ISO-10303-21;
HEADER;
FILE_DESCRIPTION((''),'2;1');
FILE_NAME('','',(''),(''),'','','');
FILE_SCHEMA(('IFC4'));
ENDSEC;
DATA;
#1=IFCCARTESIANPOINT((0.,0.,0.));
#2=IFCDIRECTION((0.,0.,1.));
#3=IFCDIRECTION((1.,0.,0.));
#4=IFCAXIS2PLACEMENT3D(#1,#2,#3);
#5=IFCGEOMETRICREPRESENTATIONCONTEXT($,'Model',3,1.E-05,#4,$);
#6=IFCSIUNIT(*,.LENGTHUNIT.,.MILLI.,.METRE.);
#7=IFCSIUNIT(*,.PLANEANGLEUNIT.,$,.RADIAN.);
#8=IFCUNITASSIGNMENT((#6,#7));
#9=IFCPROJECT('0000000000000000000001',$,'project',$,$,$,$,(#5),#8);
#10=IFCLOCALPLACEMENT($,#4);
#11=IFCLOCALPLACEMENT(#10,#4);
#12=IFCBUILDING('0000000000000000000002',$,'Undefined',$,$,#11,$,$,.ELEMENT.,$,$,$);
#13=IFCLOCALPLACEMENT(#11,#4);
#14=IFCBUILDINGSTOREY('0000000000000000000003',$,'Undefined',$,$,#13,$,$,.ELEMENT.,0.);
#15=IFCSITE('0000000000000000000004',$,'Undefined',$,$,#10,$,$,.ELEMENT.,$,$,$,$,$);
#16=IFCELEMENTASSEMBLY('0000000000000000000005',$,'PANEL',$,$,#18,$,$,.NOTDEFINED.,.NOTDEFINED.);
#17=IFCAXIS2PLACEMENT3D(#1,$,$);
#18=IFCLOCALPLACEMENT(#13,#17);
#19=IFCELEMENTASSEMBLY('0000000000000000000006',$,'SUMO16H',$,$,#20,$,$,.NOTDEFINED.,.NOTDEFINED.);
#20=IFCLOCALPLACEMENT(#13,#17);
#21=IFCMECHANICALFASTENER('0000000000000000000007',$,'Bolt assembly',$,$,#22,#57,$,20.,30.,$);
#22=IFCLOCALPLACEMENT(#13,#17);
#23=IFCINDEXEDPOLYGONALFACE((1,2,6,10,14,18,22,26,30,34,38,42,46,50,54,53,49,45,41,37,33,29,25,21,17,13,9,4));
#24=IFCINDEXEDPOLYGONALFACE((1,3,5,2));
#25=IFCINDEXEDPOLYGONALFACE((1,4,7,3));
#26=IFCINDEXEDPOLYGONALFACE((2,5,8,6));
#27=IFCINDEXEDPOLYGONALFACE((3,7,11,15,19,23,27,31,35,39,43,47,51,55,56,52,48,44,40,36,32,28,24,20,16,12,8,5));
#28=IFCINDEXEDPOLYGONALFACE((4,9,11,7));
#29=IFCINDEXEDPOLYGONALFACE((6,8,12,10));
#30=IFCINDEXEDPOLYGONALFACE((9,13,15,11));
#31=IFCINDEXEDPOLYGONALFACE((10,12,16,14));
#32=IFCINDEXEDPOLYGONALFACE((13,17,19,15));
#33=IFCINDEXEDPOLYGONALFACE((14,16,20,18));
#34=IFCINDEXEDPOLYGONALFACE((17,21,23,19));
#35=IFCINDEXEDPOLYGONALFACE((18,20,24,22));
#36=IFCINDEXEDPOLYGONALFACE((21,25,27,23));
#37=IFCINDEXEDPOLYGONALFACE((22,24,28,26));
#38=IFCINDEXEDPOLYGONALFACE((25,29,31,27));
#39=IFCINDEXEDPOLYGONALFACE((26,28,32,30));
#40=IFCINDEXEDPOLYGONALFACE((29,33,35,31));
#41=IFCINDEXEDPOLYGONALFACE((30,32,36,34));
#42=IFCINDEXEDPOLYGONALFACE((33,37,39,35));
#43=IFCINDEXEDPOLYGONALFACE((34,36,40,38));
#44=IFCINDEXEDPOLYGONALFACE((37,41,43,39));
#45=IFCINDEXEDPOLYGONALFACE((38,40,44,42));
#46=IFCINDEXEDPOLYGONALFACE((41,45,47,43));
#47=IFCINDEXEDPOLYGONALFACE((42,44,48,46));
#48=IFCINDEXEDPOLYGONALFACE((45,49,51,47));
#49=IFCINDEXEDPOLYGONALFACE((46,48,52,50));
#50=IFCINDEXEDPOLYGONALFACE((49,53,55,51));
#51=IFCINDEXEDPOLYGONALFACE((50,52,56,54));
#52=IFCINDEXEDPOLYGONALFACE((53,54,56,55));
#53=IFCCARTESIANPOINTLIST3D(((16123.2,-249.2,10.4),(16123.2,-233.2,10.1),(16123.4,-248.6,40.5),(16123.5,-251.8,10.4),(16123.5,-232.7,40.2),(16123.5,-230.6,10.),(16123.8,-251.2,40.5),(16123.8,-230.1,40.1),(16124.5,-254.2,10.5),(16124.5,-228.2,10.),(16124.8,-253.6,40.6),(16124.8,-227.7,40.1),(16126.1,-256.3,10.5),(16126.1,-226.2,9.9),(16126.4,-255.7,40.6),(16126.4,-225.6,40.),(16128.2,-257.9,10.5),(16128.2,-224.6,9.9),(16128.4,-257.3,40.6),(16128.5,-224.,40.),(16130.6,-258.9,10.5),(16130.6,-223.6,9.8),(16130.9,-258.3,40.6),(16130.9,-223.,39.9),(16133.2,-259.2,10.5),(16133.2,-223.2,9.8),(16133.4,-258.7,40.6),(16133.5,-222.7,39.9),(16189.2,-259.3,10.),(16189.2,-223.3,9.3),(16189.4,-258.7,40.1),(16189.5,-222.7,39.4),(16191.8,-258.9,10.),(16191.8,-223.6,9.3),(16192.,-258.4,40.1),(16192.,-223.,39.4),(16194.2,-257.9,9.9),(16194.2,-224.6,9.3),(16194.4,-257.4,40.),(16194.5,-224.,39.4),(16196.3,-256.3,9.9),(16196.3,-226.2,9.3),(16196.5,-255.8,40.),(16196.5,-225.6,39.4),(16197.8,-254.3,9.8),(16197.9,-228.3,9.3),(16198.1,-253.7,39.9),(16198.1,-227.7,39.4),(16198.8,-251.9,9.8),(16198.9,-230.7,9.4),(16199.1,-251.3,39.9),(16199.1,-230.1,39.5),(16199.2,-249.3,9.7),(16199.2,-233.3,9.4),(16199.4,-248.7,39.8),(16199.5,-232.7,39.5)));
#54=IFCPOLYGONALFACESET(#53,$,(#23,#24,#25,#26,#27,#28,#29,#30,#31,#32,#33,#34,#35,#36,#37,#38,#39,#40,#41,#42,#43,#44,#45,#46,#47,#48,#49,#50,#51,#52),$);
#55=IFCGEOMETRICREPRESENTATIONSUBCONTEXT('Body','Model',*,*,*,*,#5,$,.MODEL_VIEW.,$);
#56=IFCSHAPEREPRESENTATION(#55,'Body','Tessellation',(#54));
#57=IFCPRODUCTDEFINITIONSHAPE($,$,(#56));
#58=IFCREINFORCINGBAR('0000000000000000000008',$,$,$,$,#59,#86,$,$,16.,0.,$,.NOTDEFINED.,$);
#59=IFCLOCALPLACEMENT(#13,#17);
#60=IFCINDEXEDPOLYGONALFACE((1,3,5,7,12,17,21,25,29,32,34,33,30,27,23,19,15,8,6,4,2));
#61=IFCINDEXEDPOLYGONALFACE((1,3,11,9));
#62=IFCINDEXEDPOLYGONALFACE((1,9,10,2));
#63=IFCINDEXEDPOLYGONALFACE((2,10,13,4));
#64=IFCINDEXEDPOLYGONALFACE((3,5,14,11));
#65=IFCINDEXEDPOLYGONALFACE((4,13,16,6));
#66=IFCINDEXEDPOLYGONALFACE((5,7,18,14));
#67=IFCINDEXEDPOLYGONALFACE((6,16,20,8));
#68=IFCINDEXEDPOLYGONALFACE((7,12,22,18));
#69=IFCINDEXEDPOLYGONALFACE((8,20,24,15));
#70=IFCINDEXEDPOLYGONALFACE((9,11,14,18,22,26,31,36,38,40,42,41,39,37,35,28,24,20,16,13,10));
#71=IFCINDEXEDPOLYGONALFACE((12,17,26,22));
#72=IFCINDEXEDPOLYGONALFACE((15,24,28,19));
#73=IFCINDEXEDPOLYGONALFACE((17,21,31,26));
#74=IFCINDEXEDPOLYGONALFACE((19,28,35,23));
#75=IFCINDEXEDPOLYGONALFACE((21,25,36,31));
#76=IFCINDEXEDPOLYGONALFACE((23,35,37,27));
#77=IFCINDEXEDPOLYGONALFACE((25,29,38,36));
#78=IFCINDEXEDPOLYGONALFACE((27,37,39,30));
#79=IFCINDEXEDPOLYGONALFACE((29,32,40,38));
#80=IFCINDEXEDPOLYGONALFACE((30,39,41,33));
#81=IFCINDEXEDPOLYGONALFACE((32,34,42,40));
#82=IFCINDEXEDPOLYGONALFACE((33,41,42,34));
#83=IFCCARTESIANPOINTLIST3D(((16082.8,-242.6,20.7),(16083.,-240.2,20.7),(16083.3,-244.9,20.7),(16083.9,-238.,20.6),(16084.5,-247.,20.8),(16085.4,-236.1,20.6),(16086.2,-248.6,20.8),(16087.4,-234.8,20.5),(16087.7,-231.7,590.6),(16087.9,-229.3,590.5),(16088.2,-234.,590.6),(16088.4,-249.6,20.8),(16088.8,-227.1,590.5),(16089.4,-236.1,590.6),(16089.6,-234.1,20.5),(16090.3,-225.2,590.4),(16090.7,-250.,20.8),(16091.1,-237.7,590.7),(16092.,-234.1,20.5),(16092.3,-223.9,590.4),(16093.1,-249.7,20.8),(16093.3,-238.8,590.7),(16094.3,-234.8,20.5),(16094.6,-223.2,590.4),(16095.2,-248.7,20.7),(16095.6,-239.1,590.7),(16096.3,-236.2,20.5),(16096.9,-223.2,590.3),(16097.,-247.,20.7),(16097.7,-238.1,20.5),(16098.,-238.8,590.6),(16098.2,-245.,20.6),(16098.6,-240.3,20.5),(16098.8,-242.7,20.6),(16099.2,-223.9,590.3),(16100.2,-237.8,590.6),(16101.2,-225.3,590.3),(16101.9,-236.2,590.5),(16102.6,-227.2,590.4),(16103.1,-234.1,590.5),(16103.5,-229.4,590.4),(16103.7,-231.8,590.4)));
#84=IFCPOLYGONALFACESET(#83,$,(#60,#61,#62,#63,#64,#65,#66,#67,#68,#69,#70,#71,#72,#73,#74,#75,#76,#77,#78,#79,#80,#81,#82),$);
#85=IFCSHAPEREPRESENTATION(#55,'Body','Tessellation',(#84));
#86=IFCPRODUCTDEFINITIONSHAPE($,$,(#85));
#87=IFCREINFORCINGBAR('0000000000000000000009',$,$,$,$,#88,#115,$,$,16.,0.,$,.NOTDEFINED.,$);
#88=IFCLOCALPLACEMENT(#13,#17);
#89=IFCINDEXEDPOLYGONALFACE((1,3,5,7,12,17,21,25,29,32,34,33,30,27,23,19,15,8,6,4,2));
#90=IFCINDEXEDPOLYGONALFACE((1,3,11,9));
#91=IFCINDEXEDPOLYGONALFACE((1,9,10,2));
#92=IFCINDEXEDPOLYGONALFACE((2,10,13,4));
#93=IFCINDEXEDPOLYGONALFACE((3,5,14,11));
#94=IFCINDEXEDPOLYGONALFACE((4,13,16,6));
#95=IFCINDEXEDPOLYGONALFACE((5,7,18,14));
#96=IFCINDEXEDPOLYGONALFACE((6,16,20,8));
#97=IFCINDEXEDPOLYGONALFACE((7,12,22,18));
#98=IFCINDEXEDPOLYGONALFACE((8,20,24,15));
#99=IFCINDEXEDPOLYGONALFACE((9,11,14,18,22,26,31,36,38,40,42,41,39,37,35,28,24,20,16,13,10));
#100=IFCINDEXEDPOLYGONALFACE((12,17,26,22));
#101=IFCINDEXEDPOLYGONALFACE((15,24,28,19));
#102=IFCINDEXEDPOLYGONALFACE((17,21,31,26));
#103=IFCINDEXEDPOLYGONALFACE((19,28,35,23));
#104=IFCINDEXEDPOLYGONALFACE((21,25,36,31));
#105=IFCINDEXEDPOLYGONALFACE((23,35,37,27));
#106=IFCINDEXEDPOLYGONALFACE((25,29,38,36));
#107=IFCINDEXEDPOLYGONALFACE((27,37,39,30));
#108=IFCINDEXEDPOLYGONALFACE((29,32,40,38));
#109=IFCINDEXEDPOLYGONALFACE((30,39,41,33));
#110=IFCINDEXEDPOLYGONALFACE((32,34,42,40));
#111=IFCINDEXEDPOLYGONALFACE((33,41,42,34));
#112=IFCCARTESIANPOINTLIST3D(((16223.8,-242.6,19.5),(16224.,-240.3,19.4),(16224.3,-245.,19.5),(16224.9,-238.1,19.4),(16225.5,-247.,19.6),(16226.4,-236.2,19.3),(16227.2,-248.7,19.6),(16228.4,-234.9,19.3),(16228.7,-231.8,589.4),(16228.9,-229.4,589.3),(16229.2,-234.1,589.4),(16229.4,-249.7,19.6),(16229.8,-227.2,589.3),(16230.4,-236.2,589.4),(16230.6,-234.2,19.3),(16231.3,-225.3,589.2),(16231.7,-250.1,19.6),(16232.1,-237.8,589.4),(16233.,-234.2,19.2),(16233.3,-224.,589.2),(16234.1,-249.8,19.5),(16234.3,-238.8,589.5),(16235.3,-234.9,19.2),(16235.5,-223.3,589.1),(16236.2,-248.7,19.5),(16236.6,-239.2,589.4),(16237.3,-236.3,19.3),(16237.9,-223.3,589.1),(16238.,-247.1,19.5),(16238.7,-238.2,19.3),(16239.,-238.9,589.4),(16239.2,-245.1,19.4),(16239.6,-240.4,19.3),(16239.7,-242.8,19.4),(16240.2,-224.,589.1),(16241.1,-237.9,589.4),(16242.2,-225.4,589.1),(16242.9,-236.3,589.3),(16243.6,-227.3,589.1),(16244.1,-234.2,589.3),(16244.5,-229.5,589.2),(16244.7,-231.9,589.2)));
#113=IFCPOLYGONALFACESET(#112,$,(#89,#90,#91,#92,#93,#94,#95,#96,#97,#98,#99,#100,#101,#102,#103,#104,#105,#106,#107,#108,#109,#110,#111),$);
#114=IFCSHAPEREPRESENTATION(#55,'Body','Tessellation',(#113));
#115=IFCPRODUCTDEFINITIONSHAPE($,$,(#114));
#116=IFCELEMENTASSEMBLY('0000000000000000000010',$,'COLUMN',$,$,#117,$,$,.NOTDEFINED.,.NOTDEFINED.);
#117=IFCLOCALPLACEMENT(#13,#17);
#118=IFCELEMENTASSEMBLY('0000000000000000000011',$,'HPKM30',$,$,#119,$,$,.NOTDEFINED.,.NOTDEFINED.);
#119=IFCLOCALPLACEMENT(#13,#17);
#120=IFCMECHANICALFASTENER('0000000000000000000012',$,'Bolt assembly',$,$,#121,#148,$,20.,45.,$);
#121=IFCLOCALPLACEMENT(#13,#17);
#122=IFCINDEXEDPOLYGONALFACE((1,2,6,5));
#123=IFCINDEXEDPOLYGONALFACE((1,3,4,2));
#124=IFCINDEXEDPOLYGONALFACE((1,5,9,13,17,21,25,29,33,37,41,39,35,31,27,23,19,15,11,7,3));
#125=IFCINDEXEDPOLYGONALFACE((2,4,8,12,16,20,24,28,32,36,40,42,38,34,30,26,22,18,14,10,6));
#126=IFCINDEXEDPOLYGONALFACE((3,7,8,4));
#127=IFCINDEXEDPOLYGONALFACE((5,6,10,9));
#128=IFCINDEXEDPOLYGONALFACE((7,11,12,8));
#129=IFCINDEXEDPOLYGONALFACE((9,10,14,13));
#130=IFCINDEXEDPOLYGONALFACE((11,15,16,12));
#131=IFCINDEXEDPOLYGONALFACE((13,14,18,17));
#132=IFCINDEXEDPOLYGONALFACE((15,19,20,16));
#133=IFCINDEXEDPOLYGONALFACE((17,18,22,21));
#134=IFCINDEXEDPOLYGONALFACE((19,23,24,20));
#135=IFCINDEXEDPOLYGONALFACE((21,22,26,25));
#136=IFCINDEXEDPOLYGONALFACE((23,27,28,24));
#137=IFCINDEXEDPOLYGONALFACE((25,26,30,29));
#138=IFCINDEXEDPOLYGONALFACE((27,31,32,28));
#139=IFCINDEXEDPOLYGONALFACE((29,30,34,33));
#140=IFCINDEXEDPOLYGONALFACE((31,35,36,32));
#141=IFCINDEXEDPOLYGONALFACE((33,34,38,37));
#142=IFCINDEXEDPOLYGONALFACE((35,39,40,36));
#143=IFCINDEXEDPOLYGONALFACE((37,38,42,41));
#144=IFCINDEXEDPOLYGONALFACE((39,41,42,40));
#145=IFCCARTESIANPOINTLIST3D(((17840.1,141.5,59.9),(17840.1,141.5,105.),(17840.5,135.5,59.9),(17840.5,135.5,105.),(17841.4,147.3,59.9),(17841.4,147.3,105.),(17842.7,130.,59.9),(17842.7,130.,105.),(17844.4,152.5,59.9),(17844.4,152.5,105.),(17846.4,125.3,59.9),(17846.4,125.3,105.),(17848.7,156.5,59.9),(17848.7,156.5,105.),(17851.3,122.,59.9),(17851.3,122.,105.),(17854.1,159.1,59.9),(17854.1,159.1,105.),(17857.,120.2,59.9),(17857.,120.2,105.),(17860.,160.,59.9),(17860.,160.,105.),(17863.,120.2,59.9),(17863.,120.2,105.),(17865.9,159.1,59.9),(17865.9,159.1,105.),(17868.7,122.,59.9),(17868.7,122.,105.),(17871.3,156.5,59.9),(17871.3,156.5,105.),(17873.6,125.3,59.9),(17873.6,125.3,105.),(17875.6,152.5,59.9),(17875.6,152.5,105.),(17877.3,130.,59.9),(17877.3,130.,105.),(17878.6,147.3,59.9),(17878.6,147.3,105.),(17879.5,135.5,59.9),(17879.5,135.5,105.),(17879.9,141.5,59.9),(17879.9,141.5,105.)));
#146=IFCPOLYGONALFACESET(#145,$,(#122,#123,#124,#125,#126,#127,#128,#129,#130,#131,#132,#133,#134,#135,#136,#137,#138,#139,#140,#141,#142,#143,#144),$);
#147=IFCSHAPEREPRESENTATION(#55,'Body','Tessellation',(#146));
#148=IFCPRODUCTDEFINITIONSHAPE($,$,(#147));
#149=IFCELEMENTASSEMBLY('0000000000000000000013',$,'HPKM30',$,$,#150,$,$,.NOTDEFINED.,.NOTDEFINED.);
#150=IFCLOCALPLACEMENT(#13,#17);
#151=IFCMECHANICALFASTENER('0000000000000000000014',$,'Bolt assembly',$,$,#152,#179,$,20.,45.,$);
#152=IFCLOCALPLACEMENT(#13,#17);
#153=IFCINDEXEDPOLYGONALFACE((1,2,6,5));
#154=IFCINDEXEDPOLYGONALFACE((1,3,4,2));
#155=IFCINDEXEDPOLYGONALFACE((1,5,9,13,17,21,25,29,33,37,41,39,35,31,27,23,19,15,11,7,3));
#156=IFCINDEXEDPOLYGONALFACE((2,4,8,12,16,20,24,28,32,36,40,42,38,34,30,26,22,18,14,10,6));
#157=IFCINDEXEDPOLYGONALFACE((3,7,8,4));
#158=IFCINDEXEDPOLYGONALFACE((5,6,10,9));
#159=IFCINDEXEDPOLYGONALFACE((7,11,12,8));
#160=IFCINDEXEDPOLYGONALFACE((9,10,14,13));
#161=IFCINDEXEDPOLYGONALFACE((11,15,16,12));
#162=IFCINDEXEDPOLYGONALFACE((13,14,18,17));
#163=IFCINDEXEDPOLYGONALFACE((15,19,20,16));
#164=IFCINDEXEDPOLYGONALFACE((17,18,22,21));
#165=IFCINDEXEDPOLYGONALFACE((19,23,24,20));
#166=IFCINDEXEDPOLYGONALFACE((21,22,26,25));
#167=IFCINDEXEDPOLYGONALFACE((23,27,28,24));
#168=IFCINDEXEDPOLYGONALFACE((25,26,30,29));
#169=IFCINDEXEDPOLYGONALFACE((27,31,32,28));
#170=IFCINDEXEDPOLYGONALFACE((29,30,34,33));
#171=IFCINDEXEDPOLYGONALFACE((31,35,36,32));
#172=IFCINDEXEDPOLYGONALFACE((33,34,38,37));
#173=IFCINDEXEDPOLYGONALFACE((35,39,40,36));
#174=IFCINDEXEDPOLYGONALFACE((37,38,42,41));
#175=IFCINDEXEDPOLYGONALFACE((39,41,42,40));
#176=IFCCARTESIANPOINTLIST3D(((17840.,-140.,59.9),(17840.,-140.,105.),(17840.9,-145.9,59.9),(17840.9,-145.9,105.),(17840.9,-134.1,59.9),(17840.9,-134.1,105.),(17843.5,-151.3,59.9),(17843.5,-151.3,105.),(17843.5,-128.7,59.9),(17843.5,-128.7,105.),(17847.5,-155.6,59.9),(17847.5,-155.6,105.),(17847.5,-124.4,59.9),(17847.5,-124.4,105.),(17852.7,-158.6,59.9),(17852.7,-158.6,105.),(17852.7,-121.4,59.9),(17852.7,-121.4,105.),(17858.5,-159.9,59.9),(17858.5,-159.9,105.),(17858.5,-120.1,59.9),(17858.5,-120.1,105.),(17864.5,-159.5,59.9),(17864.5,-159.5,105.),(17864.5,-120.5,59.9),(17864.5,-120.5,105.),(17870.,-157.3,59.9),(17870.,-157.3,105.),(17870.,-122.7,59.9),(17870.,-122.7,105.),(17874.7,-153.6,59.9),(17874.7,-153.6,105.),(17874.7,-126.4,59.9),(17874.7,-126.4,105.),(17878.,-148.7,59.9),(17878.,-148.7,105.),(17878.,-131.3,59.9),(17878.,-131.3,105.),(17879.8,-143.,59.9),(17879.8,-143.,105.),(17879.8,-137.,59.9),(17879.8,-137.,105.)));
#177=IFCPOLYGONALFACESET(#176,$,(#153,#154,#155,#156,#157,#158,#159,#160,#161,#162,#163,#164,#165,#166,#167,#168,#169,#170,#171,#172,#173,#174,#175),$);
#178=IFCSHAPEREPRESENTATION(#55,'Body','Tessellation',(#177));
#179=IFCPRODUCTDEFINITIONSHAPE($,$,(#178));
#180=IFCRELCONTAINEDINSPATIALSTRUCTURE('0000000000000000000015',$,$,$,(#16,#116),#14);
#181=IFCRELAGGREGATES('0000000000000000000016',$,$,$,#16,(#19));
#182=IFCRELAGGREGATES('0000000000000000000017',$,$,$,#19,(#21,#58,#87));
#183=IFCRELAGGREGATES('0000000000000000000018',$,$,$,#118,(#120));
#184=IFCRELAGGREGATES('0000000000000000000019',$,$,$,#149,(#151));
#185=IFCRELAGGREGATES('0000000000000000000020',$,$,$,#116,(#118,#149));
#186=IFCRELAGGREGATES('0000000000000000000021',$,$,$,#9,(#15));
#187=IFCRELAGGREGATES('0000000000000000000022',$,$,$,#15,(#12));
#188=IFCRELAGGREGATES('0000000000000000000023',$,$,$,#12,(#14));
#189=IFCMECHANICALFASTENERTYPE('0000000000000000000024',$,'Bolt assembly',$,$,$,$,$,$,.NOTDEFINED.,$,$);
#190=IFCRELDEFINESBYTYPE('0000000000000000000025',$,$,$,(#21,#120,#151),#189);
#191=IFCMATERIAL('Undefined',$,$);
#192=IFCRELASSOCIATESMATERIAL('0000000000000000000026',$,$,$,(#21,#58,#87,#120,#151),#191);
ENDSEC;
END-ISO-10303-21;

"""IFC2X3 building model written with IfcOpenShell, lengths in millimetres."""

from ifc_helpers import new_model, entity, si_unit, frame, frame_2d, origin_with_axes, origin_2d_with_axis, place, context, subcontext, project, spatial, polyline, circle_curve, parameter, trimmed, segment, composite_curve, circle, outline, extrude, source, transform, mapped, material, type_object, element, aggregate, save


model = new_model("IFC2X3")

# Units and contexts
model_context = context("Model", 3, precision=1e-05, world=origin_with_axes())
body_context = subcontext(model_context, "Body", "Model", "MODEL_VIEW")
ifc_project = project(units=[si_unit("LENGTHUNIT", "METRE", prefix="MILLI"), si_unit("PLANEANGLEUNIT", "RADIAN")], contexts=[model_context])

# Site, building, storey
site_placement = place(None, origin_with_axes())
site = spatial("IfcSite", under=ifc_project, at=site_placement, Name="Undefined", CompositionType="ELEMENT")
building_placement = place(site_placement, origin_with_axes())
building = spatial("IfcBuilding", under=site, at=building_placement, Name="Undefined", CompositionType="ELEMENT")
storey_placement = place(building_placement, origin_with_axes())
storey = spatial("IfcBuildingStorey", under=building, at=storey_placement, Name="Undefined", CompositionType="ELEMENT", Elevation=0.0)

# Element assemblies
assembly_1_placement = place(storey_placement, origin_with_axes())
assembly_1 = element("IfcElementAssembly", 1, at=assembly_1_placement, inside=storey, Name="PANEL", AssemblyPlace="NOTDEFINED", PredefinedType="NOTDEFINED")
assembly_2_placement = place(assembly_1_placement, origin_with_axes())
assembly_2 = element("IfcElementAssembly", 2, at=assembly_2_placement, Name="SUMO16H", AssemblyPlace="NOTDEFINED", PredefinedType="NOTDEFINED")
aggregate(assembly_1, [assembly_2])

# Shared definitions
ifc_material_1 = material(Name="Undefined")

# Mechanical fastener
mechanical_fastener_type = type_object("IfcMechanicalFastenerType", Name="Bolt assembly")
shared_shape_1 = source(origin_with_axes(), body_context, "Body", "SweptSolid", [
    extrude(outline(composite_curve([segment(polyline([(-28.0, 18.0), (28.0, 18.0)]), True, "CONTINUOUS"), segment(trimmed(circle_curve(frame_2d((28.0, 8.0), x_axis=(0.0, 1.0)), 10.0), [parameter(0.0)], [parameter(4.712389)], False, "PARAMETER"), True, "CONTINUOUS"), segment(polyline([(38.0, 8.0), (38.0, -8.0)]), True, "CONTINUOUS"), segment(trimmed(circle_curve(frame_2d((28.0, -8.0), x_axis=(1.0, 0.0)), 10.0), [parameter(0.0)], [parameter(4.712389)], False, "PARAMETER"), True, "CONTINUOUS"), segment(polyline([(28.0, -18.0), (-28.0, -18.0)]), True, "CONTINUOUS"), segment(trimmed(circle_curve(frame_2d((-28.0, -8.0), x_axis=(0.0, -1.0)), 10.0), [parameter(0.0)], [parameter(4.712389)], False, "PARAMETER"), True, "CONTINUOUS"), segment(polyline([(-38.0, -8.0), (-38.0, 8.0)]), True, "CONTINUOUS"), segment(trimmed(circle_curve(frame_2d((-28.0, 8.0), x_axis=(-1.0, 0.0)), 10.0), [parameter(0.0)], [parameter(4.712389)], False, "PARAMETER"), True, "DISCONTINUOUS")], self_intersect=False)), frame((0.0, -30.0, 0.0), z_axis=(0.0, 1.0, 0.0), x_axis=(1.0, 0.0, 0.0)), (0.0, 0.0, 1.0), 30.1),
])
mechanical_fastener_1_placement = place(assembly_2_placement, frame((16161.2, -241.2, 10.0), z_axis=(-0.000494, -0.999818, 0.019097), x_axis=(-0.999963, 0.000658, 0.008607)))
mechanical_fastener_1 = element("IfcMechanicalFastener", 3, at=mechanical_fastener_1_placement, type_object=mechanical_fastener_type, material=ifc_material_1, Name="Bolt assembly", NominalDiameter=20.0, NominalLength=30.0, context=body_context, shape_type="MappedRepresentation", body=[
    mapped(shared_shape_1, transform((0.0, 0.0, 0.0))),
])

# Reinforcing bars
shared_shape_2 = source(origin_with_axes(), body_context, "Body", "AdvancedSweptSolid", [
    entity("IfcSweptDiskSolid", entity("IfcTrimmedCurve", entity("IfcLine", entity("IfcCartesianPoint", [0.0, 0.0, 0.0]), entity("IfcVector", entity("IfcDirection", [1.0, 0.0, 0.0]), 1.0)), [entity("IfcParameterValue", 0.0)], [entity("IfcParameterValue", 570.0)], True, "PARAMETER"), 8.0, None, 0.0, 570.0),
])
reinforcing_bar_1_placement = place(assembly_2_placement, frame((16090.8, -242.0, 20.6), z_axis=(-0.006955, -0.999792, 0.019153), x_axis=(0.008618, 0.019092, 0.999781)))
reinforcing_bar_1 = element("IfcReinforcingBar", 4, at=reinforcing_bar_1_placement, material=ifc_material_1, BarRole="NOTDEFINED", CrossSectionArea=0.0, NominalDiameter=16.0, context=body_context, shape_type="MappedRepresentation", body=[
    mapped(shared_shape_2, transform((0.0, 0.0, 0.0))),
])
shared_shape_3 = source(origin_with_axes(), body_context, "Body", "AdvancedSweptSolid", [
    entity("IfcSweptDiskSolid", entity("IfcTrimmedCurve", entity("IfcLine", entity("IfcCartesianPoint", [0.0, 0.0, 0.0]), entity("IfcVector", entity("IfcDirection", [1.0, 0.0, 0.0]), 1.0)), [entity("IfcParameterValue", 0.0)], [entity("IfcParameterValue", 570.0)], True, "PARAMETER"), 8.0, None, 0.0, 570.0),
])
reinforcing_bar_2_placement = place(assembly_2_placement, frame((16231.8, -242.1, 19.4), z_axis=(-0.006955, -0.999792, 0.019153), x_axis=(0.008618, 0.019092, 0.999781)))
reinforcing_bar_2 = element("IfcReinforcingBar", 5, at=reinforcing_bar_2_placement, material=ifc_material_1, BarRole="NOTDEFINED", CrossSectionArea=0.0, NominalDiameter=16.0, context=body_context, shape_type="MappedRepresentation", body=[
    mapped(shared_shape_3, transform((0.0, 0.0, 0.0))),
])
aggregate(assembly_2, [mechanical_fastener_1, reinforcing_bar_1, reinforcing_bar_2])

# Element assemblies, mechanical fasteners
assembly_3_placement = place(storey_placement, origin_with_axes())
assembly_3 = element("IfcElementAssembly", 6, at=assembly_3_placement, inside=storey, Name="COLUMN", AssemblyPlace="NOTDEFINED", PredefinedType="NOTDEFINED")
assembly_4_placement = place(assembly_3_placement, origin_with_axes())
assembly_4 = element("IfcElementAssembly", 7, at=assembly_4_placement, Name="HPKM30", AssemblyPlace="NOTDEFINED", PredefinedType="NOTDEFINED")
shared_shape_4 = source(origin_with_axes(), body_context, "Body", "SweptSolid", [
    extrude(circle(Radius=20.0, at=origin_2d_with_axis()), frame((0.0, -45.0, 0.0), z_axis=(0.0, 1.0, 0.0), x_axis=(1.0, 0.0, 0.0)), (0.0, 0.0, 1.0), 45.1),
])
mechanical_fastener_2_placement = place(assembly_4_placement, frame((17860.0, 140.0, 60.0), z_axis=(-1.0, 0.0, 0.0), x_axis=(0.0, 1.0, 0.0)))
mechanical_fastener_2 = element("IfcMechanicalFastener", 8, at=mechanical_fastener_2_placement, type_object=mechanical_fastener_type, material=ifc_material_1, Name="Bolt assembly", NominalDiameter=20.0, NominalLength=45.0, context=body_context, shape_type="MappedRepresentation", body=[
    mapped(shared_shape_4, transform((0.0, 0.0, 0.0))),
])
aggregate(assembly_4, [mechanical_fastener_2])
assembly_5_placement = place(assembly_3_placement, origin_with_axes())
assembly_5 = element("IfcElementAssembly", 9, at=assembly_5_placement, Name="HPKM30", AssemblyPlace="NOTDEFINED", PredefinedType="NOTDEFINED")
mechanical_fastener_3_placement = place(assembly_5_placement, frame((17860.0, -140.0, 60.0), z_axis=(0.0, -1.0, 0.0), x_axis=(-1.0, 0.0, 0.0)))
mechanical_fastener_3 = element("IfcMechanicalFastener", 10, at=mechanical_fastener_3_placement, type_object=mechanical_fastener_type, material=ifc_material_1, Name="Bolt assembly", NominalDiameter=20.0, NominalLength=45.0, context=body_context, shape_type="MappedRepresentation", body=[
    mapped(shared_shape_4, transform((0.0, 0.0, 0.0))),
])
aggregate(assembly_5, [mechanical_fastener_3])

aggregate(assembly_3, [assembly_4, assembly_5])

save(model, "model.ifc")
